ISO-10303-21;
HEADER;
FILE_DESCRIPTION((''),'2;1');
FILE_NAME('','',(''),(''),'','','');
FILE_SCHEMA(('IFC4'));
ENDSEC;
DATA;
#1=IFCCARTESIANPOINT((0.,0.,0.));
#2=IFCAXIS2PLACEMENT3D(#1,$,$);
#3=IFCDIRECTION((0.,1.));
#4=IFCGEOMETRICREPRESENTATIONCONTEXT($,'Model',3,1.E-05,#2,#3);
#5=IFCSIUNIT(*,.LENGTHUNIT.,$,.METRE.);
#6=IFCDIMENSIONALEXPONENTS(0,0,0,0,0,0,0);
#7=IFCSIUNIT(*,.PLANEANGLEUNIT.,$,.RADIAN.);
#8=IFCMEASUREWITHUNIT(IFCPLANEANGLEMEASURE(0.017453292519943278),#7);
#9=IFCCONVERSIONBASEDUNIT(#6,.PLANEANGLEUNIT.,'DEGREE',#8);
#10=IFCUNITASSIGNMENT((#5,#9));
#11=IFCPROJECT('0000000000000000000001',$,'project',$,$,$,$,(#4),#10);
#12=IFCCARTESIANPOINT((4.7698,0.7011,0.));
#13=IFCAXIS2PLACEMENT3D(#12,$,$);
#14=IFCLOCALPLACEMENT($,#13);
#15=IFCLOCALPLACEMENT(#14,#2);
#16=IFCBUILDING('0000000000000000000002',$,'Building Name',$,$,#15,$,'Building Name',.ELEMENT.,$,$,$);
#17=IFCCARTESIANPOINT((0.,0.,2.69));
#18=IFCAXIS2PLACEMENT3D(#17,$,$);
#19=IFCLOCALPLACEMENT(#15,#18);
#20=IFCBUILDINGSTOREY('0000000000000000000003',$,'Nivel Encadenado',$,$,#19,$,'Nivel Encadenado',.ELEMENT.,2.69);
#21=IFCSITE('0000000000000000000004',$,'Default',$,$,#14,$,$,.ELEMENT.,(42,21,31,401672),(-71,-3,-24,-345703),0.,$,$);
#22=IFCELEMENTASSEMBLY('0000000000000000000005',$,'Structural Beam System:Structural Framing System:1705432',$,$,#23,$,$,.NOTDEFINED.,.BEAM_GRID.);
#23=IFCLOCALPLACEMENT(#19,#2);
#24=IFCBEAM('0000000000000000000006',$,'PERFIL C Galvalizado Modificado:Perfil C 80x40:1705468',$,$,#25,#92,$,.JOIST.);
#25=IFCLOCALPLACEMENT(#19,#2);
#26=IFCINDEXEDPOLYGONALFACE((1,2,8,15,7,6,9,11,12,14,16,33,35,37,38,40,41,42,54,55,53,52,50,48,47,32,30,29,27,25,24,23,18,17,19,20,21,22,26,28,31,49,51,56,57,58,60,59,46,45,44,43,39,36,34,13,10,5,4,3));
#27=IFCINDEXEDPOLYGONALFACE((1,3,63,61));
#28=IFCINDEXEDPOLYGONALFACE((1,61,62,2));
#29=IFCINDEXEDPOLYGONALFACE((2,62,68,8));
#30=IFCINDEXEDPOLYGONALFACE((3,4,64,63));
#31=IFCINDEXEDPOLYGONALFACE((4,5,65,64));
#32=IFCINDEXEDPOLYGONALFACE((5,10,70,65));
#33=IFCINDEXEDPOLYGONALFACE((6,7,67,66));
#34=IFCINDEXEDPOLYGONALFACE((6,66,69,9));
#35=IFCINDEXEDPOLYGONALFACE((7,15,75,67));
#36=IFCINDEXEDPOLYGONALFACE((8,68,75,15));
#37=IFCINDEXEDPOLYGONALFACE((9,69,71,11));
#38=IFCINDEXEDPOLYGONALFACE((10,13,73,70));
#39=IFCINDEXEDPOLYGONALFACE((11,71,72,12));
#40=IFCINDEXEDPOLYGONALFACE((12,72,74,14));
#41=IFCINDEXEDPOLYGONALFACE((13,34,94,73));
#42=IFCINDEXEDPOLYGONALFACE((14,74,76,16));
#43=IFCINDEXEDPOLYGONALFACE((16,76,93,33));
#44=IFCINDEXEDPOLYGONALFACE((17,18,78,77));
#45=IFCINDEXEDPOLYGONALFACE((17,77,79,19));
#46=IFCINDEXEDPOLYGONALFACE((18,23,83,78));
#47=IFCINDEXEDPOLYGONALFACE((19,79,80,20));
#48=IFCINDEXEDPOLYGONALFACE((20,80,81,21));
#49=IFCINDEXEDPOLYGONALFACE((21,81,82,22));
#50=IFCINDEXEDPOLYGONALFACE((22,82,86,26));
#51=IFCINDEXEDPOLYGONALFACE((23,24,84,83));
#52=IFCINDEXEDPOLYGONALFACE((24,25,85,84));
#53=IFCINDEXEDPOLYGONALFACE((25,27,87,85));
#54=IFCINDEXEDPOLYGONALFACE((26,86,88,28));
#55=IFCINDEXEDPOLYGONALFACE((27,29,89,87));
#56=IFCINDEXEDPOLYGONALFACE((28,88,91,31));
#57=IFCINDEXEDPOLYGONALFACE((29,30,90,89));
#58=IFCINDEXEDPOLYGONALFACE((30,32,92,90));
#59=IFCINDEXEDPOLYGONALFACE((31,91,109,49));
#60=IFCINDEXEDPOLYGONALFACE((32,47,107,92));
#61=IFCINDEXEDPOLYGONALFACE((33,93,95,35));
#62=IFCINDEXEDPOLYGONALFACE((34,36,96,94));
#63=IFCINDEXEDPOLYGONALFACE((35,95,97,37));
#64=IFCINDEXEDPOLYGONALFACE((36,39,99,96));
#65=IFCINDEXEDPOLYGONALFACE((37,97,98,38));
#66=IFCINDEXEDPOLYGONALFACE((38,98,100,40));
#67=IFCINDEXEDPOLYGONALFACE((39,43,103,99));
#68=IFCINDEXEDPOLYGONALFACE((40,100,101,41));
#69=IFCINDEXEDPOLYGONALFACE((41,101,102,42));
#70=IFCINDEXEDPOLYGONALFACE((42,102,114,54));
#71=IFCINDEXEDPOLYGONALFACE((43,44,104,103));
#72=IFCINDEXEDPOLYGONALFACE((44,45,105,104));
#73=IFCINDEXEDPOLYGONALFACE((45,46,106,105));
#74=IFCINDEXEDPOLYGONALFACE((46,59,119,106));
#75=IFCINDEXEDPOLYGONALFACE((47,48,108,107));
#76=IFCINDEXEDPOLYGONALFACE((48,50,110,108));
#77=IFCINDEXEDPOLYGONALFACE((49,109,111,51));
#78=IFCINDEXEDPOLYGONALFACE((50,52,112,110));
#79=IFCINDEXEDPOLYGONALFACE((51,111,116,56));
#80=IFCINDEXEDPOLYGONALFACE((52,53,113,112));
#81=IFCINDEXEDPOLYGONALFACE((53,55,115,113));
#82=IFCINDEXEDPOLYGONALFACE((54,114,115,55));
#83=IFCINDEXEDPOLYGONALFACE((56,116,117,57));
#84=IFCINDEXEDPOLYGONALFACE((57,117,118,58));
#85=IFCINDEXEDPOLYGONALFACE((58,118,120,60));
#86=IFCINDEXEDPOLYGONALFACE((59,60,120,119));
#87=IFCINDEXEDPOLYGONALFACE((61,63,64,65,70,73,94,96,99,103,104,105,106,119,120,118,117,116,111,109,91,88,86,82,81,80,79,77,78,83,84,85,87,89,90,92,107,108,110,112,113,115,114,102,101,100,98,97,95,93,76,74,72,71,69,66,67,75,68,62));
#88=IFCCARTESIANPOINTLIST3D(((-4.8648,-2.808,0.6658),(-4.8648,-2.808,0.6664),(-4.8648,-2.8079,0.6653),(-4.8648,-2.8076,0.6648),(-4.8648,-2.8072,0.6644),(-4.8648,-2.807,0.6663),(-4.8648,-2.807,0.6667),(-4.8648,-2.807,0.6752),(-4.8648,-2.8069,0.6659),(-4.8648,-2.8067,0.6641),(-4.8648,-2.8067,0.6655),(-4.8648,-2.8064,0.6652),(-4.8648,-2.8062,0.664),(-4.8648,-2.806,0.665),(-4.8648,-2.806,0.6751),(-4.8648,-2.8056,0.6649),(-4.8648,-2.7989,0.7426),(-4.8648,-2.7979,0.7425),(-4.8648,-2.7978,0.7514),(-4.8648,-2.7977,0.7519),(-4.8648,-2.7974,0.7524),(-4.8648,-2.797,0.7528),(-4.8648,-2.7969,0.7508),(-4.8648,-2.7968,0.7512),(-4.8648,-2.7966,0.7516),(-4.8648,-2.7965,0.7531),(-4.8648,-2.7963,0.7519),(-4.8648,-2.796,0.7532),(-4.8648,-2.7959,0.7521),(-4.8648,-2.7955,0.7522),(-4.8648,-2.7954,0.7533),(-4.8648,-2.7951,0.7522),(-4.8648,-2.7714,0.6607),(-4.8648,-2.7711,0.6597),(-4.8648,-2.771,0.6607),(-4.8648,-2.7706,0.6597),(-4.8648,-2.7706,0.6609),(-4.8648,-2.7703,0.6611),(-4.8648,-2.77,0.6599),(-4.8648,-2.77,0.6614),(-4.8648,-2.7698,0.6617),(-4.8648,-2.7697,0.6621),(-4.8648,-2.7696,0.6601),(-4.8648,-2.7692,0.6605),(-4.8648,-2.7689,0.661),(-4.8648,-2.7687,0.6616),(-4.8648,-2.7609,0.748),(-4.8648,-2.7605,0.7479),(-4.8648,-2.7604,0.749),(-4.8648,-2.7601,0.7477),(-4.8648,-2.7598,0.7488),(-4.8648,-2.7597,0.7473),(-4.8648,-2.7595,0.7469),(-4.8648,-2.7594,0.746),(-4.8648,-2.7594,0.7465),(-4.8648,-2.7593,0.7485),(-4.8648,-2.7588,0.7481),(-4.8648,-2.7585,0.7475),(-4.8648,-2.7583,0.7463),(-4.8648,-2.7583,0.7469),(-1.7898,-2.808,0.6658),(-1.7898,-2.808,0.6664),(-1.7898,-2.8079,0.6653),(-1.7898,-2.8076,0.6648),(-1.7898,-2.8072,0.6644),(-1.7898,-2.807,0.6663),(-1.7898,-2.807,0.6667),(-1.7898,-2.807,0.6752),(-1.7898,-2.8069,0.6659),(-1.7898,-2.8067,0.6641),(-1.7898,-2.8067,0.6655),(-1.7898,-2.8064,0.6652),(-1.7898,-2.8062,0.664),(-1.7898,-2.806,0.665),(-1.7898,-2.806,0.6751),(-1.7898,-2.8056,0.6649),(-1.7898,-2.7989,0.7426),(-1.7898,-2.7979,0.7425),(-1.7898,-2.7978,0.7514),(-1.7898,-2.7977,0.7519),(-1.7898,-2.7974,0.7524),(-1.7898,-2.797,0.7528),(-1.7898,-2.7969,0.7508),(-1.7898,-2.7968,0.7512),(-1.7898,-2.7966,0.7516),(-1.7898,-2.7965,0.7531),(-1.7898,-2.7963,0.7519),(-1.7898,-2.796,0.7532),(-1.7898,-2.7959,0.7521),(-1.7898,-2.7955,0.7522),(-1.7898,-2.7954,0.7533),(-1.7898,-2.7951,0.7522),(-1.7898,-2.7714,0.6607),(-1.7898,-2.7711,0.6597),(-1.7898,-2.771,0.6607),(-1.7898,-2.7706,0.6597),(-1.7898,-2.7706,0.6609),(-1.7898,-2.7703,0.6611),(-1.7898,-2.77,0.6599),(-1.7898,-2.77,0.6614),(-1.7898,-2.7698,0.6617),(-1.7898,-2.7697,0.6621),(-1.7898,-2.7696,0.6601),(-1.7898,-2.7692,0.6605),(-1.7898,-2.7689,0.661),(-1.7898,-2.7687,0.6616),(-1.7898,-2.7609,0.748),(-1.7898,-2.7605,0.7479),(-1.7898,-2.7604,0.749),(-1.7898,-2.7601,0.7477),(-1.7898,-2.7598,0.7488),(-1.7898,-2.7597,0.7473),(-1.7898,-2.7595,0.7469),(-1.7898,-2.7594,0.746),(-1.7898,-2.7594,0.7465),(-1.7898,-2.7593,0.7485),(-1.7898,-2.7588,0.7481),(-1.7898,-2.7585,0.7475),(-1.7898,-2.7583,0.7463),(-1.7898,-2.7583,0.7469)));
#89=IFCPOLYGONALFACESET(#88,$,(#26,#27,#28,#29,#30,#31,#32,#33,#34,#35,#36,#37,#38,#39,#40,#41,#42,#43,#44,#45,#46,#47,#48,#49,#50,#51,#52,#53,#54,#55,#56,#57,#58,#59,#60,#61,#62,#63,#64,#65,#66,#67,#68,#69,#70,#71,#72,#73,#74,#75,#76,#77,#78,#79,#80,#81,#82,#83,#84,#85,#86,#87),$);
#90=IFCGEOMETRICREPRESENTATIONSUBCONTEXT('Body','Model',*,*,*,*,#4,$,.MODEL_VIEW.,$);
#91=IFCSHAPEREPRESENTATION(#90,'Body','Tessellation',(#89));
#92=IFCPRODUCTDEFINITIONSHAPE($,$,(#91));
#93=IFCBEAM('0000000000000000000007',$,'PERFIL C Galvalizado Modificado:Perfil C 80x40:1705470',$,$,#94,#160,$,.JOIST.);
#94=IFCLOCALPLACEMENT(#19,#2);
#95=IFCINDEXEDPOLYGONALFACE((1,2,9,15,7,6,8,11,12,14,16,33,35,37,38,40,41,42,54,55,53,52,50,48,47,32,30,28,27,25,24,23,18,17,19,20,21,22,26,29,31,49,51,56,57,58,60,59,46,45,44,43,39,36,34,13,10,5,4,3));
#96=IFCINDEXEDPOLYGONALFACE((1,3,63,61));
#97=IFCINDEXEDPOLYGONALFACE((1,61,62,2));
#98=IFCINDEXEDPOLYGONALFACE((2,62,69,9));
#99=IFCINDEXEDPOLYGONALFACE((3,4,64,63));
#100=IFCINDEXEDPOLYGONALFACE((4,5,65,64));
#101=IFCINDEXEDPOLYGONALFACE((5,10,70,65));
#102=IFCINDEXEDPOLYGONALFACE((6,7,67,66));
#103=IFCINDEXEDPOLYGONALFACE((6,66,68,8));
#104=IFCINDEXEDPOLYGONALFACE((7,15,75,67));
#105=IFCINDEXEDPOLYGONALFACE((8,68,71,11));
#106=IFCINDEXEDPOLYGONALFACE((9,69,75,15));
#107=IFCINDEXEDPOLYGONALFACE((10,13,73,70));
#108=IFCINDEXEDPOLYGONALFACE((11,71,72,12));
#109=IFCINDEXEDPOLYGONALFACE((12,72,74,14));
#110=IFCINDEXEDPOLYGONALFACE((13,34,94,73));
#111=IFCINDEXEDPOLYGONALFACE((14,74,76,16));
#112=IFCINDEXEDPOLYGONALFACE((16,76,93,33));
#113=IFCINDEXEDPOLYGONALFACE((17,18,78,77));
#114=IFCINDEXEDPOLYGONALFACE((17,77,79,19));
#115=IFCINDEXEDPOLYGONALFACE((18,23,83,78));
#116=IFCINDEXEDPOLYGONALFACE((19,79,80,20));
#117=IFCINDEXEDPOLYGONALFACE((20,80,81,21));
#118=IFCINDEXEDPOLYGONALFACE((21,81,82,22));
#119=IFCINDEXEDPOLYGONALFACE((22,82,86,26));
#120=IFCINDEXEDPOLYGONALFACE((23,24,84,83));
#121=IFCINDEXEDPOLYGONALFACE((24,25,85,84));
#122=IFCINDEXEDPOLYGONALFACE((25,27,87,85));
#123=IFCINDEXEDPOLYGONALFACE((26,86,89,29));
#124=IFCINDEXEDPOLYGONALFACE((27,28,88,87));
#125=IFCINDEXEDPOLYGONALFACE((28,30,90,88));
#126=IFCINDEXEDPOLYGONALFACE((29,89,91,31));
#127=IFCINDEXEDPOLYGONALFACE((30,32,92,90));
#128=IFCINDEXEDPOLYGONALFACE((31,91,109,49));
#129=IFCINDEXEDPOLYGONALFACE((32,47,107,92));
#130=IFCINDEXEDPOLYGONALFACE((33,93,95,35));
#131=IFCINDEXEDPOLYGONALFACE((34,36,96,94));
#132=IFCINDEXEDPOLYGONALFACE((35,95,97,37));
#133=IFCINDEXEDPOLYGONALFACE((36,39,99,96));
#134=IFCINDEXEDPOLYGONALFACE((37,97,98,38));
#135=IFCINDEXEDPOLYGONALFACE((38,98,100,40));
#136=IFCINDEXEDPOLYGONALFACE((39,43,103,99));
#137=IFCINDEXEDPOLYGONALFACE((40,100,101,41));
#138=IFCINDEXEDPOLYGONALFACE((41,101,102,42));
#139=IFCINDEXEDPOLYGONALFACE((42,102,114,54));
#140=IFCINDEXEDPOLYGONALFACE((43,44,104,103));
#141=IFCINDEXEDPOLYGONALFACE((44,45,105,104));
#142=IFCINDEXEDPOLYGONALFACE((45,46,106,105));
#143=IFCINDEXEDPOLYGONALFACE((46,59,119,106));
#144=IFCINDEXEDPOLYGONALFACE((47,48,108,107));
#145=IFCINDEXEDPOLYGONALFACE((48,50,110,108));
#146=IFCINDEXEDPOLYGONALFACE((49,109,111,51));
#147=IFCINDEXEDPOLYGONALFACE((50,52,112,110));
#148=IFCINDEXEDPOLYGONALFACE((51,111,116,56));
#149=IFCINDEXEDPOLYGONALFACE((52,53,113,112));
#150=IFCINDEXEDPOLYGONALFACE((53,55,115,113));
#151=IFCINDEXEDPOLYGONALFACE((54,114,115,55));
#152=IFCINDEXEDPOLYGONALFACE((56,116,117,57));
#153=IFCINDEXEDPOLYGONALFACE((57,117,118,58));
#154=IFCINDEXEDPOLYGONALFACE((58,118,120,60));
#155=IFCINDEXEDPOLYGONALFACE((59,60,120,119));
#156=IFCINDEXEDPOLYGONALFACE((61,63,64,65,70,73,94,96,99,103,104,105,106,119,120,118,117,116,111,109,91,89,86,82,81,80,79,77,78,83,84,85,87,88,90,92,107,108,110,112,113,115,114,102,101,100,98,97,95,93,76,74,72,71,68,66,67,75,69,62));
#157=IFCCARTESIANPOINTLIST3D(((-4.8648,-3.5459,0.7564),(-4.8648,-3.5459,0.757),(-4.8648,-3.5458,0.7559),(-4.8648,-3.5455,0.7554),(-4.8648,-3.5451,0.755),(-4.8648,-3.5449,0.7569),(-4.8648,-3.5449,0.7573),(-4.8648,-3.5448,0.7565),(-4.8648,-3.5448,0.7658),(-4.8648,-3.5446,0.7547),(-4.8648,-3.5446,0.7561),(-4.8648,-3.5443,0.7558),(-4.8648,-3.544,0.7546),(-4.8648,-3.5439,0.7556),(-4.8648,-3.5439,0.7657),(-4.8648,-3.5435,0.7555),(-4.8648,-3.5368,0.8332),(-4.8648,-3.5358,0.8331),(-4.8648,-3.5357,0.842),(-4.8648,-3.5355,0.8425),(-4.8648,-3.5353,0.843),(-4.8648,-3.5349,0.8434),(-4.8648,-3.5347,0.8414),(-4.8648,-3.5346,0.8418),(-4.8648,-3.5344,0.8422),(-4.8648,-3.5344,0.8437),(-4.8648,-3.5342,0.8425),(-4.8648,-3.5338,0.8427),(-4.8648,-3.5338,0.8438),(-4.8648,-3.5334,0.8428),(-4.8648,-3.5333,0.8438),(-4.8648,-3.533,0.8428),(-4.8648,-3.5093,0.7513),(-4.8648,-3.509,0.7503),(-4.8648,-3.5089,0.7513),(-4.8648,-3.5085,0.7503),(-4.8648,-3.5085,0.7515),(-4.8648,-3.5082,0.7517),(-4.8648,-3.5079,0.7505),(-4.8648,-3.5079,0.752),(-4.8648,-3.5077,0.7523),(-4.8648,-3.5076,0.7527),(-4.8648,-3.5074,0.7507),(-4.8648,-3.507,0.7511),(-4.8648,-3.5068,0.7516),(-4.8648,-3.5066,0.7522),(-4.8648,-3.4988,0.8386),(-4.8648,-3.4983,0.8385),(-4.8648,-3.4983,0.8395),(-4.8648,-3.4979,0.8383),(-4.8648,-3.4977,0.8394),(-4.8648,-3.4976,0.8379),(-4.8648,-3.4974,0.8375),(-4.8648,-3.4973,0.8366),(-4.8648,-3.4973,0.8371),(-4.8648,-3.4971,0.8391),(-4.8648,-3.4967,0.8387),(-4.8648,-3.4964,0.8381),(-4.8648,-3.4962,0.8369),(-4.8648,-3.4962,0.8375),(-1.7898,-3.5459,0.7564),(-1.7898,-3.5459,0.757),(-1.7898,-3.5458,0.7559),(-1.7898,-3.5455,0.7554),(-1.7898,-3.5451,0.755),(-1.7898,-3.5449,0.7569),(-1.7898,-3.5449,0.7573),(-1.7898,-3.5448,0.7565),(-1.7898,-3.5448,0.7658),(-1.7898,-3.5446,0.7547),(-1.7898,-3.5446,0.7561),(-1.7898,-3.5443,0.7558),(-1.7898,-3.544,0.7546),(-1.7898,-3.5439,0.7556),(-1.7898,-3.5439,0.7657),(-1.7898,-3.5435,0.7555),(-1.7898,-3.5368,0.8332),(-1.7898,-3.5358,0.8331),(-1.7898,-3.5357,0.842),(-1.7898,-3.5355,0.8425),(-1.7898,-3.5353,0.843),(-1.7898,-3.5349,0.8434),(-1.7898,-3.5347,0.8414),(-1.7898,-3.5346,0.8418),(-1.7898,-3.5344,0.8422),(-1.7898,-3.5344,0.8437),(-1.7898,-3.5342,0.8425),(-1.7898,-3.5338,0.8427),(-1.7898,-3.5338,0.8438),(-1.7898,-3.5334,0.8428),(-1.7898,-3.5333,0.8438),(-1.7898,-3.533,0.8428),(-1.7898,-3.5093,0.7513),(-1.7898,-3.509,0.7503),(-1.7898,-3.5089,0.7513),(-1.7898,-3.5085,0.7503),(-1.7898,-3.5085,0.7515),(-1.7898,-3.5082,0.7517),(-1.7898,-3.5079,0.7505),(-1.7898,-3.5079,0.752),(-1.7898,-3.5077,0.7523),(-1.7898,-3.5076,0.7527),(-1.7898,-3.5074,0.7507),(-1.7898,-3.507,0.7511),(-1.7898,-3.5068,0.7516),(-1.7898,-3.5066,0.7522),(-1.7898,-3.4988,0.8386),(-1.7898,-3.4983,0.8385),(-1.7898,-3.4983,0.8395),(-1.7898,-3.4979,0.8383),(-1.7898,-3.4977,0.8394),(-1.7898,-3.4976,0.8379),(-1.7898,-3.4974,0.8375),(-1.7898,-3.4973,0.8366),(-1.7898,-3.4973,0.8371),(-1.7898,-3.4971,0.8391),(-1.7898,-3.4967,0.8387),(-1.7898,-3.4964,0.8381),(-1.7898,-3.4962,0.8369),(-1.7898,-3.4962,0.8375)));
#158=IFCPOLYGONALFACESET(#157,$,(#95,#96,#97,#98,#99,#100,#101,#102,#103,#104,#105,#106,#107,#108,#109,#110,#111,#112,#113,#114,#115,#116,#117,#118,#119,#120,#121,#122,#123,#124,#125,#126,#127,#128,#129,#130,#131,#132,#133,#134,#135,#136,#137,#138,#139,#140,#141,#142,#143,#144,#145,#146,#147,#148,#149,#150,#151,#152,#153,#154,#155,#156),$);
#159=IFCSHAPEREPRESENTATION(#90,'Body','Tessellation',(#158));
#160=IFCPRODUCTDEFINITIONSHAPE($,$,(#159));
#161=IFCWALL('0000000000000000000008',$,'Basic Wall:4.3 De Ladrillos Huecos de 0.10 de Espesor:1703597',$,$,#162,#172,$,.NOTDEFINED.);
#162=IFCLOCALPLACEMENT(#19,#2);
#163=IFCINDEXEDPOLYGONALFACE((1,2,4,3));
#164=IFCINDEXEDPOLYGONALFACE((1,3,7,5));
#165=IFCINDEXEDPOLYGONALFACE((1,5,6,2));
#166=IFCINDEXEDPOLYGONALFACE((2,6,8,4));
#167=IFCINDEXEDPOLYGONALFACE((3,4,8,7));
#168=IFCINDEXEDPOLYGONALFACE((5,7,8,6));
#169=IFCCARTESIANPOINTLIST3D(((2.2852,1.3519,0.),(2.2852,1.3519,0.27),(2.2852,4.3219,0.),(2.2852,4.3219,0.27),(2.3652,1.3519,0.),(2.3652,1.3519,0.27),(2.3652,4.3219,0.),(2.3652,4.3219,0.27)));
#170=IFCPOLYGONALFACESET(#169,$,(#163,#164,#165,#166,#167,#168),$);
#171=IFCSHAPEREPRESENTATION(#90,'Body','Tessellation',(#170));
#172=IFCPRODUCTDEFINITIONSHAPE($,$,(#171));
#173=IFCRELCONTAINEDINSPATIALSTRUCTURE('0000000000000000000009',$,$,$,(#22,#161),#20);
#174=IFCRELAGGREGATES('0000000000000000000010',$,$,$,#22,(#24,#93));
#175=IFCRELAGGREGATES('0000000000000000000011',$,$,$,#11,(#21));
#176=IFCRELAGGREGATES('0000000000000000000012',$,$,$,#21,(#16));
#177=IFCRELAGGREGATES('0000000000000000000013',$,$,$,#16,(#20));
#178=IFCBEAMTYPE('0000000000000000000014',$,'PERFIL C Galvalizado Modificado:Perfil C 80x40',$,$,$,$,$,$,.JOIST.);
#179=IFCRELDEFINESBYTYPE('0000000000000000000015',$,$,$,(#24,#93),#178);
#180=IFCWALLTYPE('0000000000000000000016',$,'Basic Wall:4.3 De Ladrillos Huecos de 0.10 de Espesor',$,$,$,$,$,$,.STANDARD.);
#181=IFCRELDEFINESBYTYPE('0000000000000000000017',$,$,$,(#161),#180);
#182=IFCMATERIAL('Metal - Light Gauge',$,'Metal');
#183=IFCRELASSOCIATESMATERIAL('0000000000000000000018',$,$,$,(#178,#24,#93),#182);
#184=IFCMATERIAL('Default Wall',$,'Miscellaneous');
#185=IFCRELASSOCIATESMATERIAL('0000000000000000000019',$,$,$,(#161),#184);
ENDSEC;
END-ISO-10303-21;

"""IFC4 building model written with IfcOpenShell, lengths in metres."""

from ifc_helpers import new_model, entity, si_unit, converted_unit, direction, frame, origin, place, context, subcontext, project, spatial, line, arc, indexed_curve, outline, extrude, source, transform, mapped, material, type_object, type_shapes, element, aggregate, save


model = new_model("IFC4")

# Units and contexts
model_context = context("Model", 3, precision=1e-05, world=origin(), true_north=direction((0.0, 1.0)))
body_context = subcontext(model_context, "Body", "Model", "MODEL_VIEW")
ifc_project = project(units=[si_unit("LENGTHUNIT", "METRE"), converted_unit("PLANEANGLEUNIT", "DEGREE", entity("IfcPlaneAngleMeasure", 0.017453292519943278), si_unit("PLANEANGLEUNIT", "RADIAN"), dimensions=[0, 0, 0, 0, 0, 0, 0])], contexts=[model_context])

# Site, building, storey
site_placement = place(None, frame((4.7698, 0.7011, 0.0)))
site = spatial("IfcSite", under=ifc_project, at=site_placement, Name="Default", CompositionType="ELEMENT", RefLatitude=(42, 21, 31, 401672), RefLongitude=(-71, -3, -24, -345703), RefElevation=0.0)
building_placement = place(site_placement, origin())
building = spatial("IfcBuilding", under=site, at=building_placement, Name="Building Name", LongName="Building Name", CompositionType="ELEMENT")
storey_placement = place(building_placement, frame((0.0, 0.0, 2.69)))
storey = spatial("IfcBuildingStorey", under=building, at=storey_placement, Name="Nivel Encadenado", LongName="Nivel Encadenado", CompositionType="ELEMENT", Elevation=2.69)

# Element assembly, beams
ifc_material_1 = material(Name="Metal - Light Gauge", Category="Metal")
assembly_1_placement = place(storey_placement, origin())
assembly_1 = element("IfcElementAssembly", 1, at=assembly_1_placement, inside=storey, Name="Structural Beam System:Structural Framing System:1705432", AssemblyPlace="NOTDEFINED", PredefinedType="BEAM_GRID")
beam_type_1 = type_object("IfcBeamType", Name="PERFIL C Galvalizado Modificado:Perfil C 80x40", PredefinedType="JOIST", material=ifc_material_1)
shared_shape_1 = source(origin(), body_context, "Body", "SweptSolid", [
    extrude(outline(indexed_curve([(-0.0428, -0.0161), (-0.034, -0.0161), (-0.034, -0.0151), (-0.0424, -0.0151), (-0.0435, -0.0146), (-0.044, -0.0135), (-0.044, 0.021), (-0.0435, 0.0222), (-0.0422, 0.0227), (0.0424, 0.0227), (0.0435, 0.0223), (0.0439, 0.0212), (0.0439, -0.0133), (0.0435, -0.0144), (0.0424, -0.0149), (0.0339, -0.0149), (0.0339, -0.0159), (0.0428, -0.0159), (0.0443, -0.0152), (0.0449, -0.0137), (0.0449, 0.0216), (0.0443, 0.0231), (0.0428, 0.0237), (-0.0426, 0.0237), (-0.0443, 0.023), (-0.045, 0.0214), (-0.045, -0.0139), (-0.0443, -0.0154)], segments=[line(1, 2, 3, 4), arc(4, 5, 6), line(6, 7), arc(7, 8, 9), line(9, 10), arc(10, 11, 12), line(12, 13), arc(13, 14, 15), line(15, 16, 17, 18), arc(18, 19, 20), line(20, 21), arc(21, 22, 23), line(23, 24), arc(24, 25, 26), line(26, 27), arc(27, 28, 1)], self_intersect=False)), frame((-1.5375, -0.0037, 0.0), z_axis=(1.0, 0.0, 0.0), x_axis=(0.0, 0.0, -1.0)), (0.0, 0.0, 1.0), 3.075),
])
type_shapes(beam_type_1, [shared_shape_1])
beam_1_placement = place(assembly_1_placement, frame((-3.3273, -2.7834, 0.7065), z_axis=(0.0, 0.121869, 0.992546), x_axis=(1.0, 0.0, 0.0)))
beam_1 = element("IfcBeam", 2, at=beam_1_placement, type_object=beam_type_1, material=ifc_material_1, Name="PERFIL C Galvalizado Modificado:Perfil C 80x40:1705468", PredefinedType="JOIST", context=body_context, shape_type="MappedRepresentation", body=[
    mapped(shared_shape_1, transform((0.0, 0.0, 0.0), scale=1.0)),
])
beam_2_placement = place(assembly_1_placement, frame((-3.3273, -3.5213, 0.7971), z_axis=(0.0, 0.121869, 0.992546), x_axis=(1.0, 0.0, 0.0)))
beam_2 = element("IfcBeam", 3, at=beam_2_placement, type_object=beam_type_1, material=ifc_material_1, Name="PERFIL C Galvalizado Modificado:Perfil C 80x40:1705470", PredefinedType="JOIST", context=body_context, shape_type="MappedRepresentation", body=[
    mapped(shared_shape_1, transform((0.0, 0.0, 0.0), scale=1.0)),
])
aggregate(assembly_1, [beam_1, beam_2])

# Wall
ifc_material_2 = material(Name="Default Wall", Category="Miscellaneous")
wall_type_1 = type_object("IfcWallType", Name="Basic Wall:4.3 De Ladrillos Huecos de 0.10 de Espesor", PredefinedType="STANDARD")
wall_1_placement = place(storey_placement, frame((2.3252, 1.3519, 0.0), z_axis=(0.0, 0.0, 1.0), x_axis=(0.0, 1.0, 0.0)))
element("IfcWall", 4, at=wall_1_placement, inside=storey, type_object=wall_type_1, material=ifc_material_2, Name="Basic Wall:4.3 De Ladrillos Huecos de 0.10 de Espesor:1703597", PredefinedType="NOTDEFINED", context=body_context, shape_type="SweptSolid", body=[
    extrude(outline(indexed_curve([(2.97, 0.04), (0.0, 0.04), (0.0, -0.04), (2.97, -0.04), (2.97, 0.04)], self_intersect=False)), origin(), (0.0, 0.0, 1.0), 0.27),
])

save(model, "model.ifc")
